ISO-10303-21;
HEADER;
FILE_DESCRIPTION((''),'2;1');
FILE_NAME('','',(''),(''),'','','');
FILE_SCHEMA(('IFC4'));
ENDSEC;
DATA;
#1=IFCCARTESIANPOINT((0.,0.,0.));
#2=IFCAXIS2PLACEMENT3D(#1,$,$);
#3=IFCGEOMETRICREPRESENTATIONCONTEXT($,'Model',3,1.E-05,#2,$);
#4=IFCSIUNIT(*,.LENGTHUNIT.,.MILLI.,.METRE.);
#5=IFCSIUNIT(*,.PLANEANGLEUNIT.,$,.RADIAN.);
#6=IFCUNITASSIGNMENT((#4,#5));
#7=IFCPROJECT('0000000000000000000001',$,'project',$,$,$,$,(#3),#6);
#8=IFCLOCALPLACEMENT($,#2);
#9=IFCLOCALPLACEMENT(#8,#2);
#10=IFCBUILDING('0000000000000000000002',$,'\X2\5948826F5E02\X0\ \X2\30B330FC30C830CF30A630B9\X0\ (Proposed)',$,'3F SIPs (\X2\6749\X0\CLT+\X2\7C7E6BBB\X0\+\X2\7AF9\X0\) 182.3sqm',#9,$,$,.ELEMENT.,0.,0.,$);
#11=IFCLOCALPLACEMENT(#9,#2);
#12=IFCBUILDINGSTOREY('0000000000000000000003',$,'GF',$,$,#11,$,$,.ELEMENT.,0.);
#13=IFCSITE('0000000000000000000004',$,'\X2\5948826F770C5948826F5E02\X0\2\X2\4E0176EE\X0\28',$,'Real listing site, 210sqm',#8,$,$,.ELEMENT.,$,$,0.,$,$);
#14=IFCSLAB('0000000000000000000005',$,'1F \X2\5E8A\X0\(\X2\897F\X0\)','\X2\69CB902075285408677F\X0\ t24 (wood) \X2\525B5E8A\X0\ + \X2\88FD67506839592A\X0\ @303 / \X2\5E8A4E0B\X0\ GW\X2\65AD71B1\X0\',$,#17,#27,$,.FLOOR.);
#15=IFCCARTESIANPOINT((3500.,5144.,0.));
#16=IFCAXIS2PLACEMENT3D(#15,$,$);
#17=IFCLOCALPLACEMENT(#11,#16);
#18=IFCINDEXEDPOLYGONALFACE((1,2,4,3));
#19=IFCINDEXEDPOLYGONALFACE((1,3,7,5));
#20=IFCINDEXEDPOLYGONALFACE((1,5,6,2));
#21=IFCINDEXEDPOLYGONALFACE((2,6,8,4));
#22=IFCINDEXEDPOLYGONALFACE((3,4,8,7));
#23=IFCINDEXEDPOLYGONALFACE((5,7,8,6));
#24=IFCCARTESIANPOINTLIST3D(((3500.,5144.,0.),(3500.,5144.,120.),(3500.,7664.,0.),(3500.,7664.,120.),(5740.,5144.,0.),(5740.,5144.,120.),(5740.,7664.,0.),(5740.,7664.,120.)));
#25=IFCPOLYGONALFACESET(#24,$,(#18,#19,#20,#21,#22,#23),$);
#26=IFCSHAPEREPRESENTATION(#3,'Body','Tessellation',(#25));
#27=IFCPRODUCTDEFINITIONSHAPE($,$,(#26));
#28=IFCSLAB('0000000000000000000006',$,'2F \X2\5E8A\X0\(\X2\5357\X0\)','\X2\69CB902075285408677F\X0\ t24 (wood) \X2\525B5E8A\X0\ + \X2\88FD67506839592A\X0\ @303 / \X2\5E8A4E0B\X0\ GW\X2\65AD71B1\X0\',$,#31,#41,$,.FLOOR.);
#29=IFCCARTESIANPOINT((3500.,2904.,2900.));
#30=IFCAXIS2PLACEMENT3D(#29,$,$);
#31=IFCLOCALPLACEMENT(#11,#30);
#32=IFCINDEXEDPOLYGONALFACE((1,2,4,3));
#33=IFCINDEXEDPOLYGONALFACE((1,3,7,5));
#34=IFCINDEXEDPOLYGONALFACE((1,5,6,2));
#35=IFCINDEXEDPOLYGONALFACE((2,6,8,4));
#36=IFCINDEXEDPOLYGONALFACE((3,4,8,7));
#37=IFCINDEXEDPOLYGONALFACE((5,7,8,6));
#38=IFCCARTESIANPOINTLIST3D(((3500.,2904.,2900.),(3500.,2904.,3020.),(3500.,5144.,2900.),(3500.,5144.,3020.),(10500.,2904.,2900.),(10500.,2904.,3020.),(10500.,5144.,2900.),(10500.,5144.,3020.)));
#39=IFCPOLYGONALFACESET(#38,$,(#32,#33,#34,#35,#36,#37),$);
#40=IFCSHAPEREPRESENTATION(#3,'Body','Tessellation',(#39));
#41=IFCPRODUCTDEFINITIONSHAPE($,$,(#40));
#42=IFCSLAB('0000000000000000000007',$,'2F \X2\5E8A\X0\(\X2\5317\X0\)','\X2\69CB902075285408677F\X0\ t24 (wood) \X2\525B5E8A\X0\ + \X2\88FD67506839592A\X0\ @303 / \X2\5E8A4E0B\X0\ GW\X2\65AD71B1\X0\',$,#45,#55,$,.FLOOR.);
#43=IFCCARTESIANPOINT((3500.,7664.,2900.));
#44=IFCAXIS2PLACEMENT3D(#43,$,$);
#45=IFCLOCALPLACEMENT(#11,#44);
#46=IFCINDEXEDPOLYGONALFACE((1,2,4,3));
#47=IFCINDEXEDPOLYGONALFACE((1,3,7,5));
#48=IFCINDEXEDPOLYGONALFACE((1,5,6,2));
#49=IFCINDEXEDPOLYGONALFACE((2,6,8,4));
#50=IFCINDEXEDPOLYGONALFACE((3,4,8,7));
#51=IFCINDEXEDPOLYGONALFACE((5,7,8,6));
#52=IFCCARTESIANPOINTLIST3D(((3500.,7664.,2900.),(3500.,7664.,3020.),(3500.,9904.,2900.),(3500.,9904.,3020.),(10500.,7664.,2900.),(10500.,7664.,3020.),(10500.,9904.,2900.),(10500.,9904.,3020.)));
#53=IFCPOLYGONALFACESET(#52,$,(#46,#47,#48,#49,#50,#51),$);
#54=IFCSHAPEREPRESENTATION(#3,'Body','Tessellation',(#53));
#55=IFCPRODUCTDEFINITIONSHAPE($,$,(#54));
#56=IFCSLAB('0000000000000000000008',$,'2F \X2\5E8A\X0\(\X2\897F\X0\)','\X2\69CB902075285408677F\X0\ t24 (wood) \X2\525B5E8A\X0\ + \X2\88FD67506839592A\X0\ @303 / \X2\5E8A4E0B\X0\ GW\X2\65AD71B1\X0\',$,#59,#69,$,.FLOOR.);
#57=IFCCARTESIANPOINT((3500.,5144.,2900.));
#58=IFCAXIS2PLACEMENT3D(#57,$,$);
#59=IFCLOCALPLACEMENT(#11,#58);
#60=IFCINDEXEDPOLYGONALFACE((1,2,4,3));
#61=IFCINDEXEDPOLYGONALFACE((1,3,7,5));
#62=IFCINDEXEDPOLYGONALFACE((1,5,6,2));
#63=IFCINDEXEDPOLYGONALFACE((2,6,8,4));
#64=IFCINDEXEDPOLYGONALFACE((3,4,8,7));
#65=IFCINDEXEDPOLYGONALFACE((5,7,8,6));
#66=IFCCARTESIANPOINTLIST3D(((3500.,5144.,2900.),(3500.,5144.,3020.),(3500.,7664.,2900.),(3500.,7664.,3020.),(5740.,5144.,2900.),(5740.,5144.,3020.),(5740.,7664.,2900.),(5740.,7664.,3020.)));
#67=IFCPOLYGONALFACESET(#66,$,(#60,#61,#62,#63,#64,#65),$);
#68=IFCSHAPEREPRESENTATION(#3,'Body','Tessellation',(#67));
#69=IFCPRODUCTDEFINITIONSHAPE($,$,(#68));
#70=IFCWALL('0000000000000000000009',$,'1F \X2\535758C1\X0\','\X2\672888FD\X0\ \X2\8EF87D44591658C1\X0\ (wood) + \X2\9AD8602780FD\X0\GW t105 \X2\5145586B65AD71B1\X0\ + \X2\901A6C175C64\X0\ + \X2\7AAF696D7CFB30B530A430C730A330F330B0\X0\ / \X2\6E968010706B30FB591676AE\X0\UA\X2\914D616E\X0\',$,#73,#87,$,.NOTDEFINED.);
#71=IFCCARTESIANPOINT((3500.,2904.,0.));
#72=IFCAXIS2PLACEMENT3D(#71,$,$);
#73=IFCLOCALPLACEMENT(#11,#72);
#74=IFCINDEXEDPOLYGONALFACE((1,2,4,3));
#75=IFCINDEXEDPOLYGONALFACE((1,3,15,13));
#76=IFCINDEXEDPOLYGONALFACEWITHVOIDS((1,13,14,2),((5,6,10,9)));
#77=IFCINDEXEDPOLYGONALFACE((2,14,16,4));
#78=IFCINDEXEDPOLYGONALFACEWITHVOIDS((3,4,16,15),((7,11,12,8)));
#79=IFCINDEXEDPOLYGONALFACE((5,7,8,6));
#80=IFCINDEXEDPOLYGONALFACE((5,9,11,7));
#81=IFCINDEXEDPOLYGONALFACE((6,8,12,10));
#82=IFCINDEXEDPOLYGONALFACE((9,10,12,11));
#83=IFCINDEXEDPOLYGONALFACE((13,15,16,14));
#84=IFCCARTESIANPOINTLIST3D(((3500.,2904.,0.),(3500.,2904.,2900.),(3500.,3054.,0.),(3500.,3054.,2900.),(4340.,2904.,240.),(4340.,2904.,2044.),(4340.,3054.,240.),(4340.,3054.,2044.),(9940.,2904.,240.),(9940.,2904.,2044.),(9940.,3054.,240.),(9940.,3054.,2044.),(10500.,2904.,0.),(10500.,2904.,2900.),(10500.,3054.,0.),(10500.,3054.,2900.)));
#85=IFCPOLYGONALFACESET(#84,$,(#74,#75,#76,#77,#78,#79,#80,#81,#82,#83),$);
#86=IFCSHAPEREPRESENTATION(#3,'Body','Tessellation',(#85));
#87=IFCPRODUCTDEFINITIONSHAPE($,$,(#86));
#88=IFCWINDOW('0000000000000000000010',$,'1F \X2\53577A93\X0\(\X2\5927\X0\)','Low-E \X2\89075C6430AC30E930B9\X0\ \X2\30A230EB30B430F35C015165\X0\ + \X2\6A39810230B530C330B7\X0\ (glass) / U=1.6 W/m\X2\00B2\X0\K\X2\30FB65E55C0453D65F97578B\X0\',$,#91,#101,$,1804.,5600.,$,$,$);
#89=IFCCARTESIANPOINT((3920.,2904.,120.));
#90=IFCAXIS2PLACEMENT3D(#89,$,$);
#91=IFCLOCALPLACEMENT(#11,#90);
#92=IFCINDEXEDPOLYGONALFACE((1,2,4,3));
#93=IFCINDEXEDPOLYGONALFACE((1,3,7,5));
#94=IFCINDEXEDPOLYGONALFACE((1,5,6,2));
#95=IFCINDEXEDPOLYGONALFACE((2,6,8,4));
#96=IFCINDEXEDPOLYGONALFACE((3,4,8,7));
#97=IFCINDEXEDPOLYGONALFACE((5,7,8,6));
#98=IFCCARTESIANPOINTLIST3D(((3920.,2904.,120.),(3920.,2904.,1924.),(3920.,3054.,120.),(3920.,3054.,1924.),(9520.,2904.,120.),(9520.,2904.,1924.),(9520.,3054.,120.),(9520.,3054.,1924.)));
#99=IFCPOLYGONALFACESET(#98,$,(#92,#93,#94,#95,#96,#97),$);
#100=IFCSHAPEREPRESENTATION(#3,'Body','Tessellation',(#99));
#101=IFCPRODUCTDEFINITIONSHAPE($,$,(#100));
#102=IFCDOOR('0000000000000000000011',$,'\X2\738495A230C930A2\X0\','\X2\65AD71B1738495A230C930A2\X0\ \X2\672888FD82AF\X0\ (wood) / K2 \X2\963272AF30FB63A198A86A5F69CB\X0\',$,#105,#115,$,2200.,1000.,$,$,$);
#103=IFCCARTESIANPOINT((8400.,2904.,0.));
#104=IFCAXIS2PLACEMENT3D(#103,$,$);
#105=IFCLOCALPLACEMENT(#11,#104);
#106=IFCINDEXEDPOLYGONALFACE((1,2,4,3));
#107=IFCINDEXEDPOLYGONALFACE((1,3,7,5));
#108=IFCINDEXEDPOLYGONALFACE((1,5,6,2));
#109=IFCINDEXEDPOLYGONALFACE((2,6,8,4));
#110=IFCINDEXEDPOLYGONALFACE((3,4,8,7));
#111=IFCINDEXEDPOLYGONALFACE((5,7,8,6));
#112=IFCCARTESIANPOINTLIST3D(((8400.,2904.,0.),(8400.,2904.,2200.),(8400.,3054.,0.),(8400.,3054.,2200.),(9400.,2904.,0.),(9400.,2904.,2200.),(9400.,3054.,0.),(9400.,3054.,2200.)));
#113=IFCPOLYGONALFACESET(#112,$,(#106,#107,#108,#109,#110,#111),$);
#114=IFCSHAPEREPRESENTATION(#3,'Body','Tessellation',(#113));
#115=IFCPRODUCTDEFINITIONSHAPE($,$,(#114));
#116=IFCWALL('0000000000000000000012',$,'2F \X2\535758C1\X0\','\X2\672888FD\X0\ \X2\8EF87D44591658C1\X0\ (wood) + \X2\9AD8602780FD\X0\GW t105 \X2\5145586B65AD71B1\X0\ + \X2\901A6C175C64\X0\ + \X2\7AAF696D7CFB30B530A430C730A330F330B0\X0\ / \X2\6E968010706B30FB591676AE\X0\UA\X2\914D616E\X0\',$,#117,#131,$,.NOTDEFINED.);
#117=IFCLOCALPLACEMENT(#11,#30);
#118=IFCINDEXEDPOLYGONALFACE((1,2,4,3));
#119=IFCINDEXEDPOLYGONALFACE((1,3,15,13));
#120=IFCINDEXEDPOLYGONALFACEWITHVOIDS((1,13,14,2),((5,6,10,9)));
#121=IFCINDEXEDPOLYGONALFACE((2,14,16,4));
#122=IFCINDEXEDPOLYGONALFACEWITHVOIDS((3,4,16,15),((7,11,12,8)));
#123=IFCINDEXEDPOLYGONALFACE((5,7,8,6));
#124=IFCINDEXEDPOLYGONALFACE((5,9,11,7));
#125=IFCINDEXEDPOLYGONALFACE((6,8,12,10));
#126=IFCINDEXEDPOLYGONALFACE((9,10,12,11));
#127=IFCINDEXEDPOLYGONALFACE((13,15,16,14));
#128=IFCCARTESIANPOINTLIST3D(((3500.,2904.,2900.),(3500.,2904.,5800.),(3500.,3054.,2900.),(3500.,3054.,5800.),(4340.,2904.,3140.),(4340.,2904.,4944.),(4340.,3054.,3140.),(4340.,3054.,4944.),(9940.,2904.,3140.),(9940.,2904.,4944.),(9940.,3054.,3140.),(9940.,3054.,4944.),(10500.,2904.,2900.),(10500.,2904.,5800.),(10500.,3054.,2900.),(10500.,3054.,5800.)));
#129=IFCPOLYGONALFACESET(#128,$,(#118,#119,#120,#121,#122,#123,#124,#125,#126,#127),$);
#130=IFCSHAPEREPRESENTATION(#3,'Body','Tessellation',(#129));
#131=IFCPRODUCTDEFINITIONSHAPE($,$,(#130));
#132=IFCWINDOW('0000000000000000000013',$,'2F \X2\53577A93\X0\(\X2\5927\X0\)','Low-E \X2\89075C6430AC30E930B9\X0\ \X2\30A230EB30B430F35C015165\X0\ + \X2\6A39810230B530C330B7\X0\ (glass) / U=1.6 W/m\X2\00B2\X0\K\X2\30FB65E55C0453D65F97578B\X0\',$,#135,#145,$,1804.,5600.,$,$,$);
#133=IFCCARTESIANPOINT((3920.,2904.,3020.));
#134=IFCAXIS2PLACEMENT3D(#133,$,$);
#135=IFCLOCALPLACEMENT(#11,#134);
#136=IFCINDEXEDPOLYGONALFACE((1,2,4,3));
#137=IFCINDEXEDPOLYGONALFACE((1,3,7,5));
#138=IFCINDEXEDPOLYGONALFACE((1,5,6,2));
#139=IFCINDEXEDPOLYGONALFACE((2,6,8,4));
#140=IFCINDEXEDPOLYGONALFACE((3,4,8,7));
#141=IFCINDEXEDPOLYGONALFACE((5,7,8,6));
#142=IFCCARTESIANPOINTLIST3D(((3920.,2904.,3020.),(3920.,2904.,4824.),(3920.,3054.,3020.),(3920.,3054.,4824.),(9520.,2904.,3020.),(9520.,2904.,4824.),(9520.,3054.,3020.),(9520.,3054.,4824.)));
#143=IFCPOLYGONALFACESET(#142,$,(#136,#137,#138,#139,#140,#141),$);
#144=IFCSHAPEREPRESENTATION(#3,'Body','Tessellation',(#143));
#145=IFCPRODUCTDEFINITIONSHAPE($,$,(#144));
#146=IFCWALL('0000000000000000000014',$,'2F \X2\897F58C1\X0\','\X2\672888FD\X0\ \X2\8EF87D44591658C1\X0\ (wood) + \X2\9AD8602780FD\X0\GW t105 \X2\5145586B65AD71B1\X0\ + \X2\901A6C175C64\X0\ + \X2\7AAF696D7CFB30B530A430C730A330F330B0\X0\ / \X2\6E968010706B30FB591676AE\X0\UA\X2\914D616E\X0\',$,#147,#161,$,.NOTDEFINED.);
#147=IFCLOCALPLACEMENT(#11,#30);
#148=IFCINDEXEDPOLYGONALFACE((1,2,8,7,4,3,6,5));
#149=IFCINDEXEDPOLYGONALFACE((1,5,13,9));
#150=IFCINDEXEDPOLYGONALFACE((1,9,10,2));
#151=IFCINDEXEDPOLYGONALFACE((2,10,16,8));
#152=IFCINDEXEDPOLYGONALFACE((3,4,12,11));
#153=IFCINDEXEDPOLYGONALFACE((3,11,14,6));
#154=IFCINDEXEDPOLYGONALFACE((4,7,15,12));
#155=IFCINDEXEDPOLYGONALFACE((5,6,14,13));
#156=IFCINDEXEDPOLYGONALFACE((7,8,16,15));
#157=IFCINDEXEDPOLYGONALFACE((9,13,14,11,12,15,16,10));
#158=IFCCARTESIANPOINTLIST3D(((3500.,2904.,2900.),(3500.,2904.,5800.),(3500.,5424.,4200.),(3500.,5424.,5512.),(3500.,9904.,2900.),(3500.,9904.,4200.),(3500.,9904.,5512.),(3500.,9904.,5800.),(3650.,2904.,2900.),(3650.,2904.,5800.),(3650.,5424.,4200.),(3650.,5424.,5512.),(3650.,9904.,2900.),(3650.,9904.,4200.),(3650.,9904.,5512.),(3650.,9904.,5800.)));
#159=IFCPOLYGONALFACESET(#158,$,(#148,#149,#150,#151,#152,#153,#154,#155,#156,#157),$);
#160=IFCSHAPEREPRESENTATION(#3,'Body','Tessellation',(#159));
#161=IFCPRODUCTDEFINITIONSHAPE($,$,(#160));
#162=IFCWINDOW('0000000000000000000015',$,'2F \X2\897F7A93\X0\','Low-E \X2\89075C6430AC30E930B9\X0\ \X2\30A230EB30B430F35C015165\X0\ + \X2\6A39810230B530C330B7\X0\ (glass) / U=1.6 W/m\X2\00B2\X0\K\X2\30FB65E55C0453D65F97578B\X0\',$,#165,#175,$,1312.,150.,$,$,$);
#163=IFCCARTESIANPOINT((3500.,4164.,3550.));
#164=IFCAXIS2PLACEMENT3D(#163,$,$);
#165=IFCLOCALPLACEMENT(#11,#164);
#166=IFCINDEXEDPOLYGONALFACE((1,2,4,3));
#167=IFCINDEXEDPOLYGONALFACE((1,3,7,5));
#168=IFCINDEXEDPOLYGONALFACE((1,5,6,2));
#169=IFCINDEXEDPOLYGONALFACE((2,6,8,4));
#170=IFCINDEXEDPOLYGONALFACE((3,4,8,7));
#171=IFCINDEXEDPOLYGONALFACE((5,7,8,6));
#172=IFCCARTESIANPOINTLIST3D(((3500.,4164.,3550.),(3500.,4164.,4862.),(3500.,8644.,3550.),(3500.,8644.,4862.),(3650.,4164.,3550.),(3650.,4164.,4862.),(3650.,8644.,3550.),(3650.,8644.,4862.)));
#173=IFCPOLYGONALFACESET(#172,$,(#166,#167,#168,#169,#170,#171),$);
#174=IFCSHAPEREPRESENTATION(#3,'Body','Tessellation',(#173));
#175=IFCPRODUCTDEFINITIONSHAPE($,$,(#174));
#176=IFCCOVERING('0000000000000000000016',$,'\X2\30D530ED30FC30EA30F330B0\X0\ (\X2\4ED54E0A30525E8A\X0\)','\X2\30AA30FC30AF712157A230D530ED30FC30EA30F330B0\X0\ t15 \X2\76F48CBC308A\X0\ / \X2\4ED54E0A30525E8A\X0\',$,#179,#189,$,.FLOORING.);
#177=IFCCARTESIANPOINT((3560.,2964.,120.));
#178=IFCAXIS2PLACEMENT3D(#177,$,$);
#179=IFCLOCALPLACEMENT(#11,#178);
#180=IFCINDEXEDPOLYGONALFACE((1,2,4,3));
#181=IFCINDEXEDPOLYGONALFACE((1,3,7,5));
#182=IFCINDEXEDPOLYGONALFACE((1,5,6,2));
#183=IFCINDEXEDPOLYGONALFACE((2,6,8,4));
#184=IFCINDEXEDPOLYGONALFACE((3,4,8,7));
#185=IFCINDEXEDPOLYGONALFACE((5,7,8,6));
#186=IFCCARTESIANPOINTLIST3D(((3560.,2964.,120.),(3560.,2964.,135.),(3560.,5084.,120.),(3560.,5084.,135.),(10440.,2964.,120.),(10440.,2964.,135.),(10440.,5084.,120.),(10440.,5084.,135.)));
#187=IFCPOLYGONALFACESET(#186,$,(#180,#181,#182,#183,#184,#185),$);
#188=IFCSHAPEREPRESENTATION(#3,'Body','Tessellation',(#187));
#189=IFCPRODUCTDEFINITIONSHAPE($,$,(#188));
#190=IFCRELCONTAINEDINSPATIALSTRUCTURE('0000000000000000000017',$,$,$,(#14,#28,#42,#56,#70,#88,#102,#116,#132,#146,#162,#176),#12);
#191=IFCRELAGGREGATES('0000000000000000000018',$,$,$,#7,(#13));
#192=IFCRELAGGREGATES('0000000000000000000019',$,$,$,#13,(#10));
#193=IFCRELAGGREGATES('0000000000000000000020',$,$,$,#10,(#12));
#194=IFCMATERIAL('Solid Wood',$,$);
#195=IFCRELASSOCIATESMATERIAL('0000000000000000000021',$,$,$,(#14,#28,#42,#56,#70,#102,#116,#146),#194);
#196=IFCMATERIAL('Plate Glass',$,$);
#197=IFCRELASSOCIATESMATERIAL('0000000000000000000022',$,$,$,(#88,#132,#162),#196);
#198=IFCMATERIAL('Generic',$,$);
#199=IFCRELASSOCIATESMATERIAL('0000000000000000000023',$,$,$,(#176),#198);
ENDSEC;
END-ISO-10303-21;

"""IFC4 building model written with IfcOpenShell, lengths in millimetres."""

from ifc_helpers import new_model, si_unit, frame, frame_2d, origin, place, context, project, spatial, rectangle, extrude, material, element, fill, save


model = new_model("IFC4")

# Units and contexts
model_context = context("Model", 3, precision=1e-05, world=origin())
ifc_project = project(units=[si_unit("LENGTHUNIT", "METRE", prefix="MILLI"), si_unit("PLANEANGLEUNIT", "RADIAN")], contexts=[model_context])

# Site, building, storey
site_placement = place(None, origin())
site = spatial("IfcSite", under=ifc_project, at=site_placement, Name="奈良県奈良市2丁目28", ObjectType="Real listing site, 210sqm", CompositionType="ELEMENT", RefElevation=0.0)
building_placement = place(site_placement, origin())
building = spatial("IfcBuilding", under=site, at=building_placement, Name="奈良市 コートハウス (Proposed)", ObjectType="3F SIPs (杉CLT+籾殻+竹) 182.3sqm", CompositionType="ELEMENT", ElevationOfRefHeight=0.0, ElevationOfTerrain=0.0)
storey_placement = place(building_placement, origin())
storey = spatial("IfcBuildingStorey", under=building, at=storey_placement, Name="GF", CompositionType="ELEMENT", Elevation=0.0)

# Slabs
ifc_material_1 = material(Name="Solid Wood")
slab_1_placement = place(storey_placement, frame((3500.0, 5144.0, 0.0)))
element("IfcSlab", 1, at=slab_1_placement, inside=storey, material=ifc_material_1, Name="1F 床(西)", Description="構造用合板 t24 (wood) 剛床 + 製材根太 @303 / 床下 GW断熱", PredefinedType="FLOOR", context=model_context, shape_type="SweptSolid", body=[
    extrude(rectangle(XDim=2240.0, YDim=2520.0, at=frame_2d((1120.0, 1260.0))), frame((3500.0, 5144.0, 0.0)), (0.0, 0.0, 1.0), 120.0),
])
slab_2_placement = place(storey_placement, frame((3500.0, 2904.0, 2900.0)))
element("IfcSlab", 2, at=slab_2_placement, inside=storey, material=ifc_material_1, Name="2F 床(南)", Description="構造用合板 t24 (wood) 剛床 + 製材根太 @303 / 床下 GW断熱", PredefinedType="FLOOR", context=model_context, shape_type="SweptSolid", body=[
    extrude(rectangle(XDim=7000.0, YDim=2240.0, at=frame_2d((3500.0, 1120.0))), frame((3500.0, 2904.0, 2900.0)), (0.0, 0.0, 1.0), 120.0),
])
slab_3_placement = place(storey_placement, frame((3500.0, 7664.0, 2900.0)))
element("IfcSlab", 3, at=slab_3_placement, inside=storey, material=ifc_material_1, Name="2F 床(北)", Description="構造用合板 t24 (wood) 剛床 + 製材根太 @303 / 床下 GW断熱", PredefinedType="FLOOR", context=model_context, shape_type="SweptSolid", body=[
    extrude(rectangle(XDim=7000.0, YDim=2240.0, at=frame_2d((3500.0, 1120.0))), frame((3500.0, 7664.0, 2900.0)), (0.0, 0.0, 1.0), 120.0),
])
slab_4_placement = place(storey_placement, frame((3500.0, 5144.0, 2900.0)))
element("IfcSlab", 4, at=slab_4_placement, inside=storey, material=ifc_material_1, Name="2F 床(西)", Description="構造用合板 t24 (wood) 剛床 + 製材根太 @303 / 床下 GW断熱", PredefinedType="FLOOR", context=model_context, shape_type="SweptSolid", body=[
    extrude(rectangle(XDim=2240.0, YDim=2520.0, at=frame_2d((1120.0, 1260.0))), frame((3500.0, 5144.0, 2900.0)), (0.0, 0.0, 1.0), 120.0),
])

# Wall, openings, window, door
wall_1_placement = place(storey_placement, frame((3500.0, 2904.0, 0.0)))
wall_1 = element("IfcWall", 5, at=wall_1_placement, inside=storey, material=ifc_material_1, Name="1F 南壁", Description="木製 軸組外壁 (wood) + 高性能GW t105 充填断熱 + 通気層 + 窯業系サイディング / 準耐火・外皮UA配慮", PredefinedType="NOTDEFINED", context=model_context, shape_type="SweptSolid", body=[
    extrude(rectangle(XDim=7000.0, YDim=150.0, at=frame_2d((3500.0, 75.0))), frame((3500.0, 2904.0, 0.0)), (0.0, 0.0, 1.0), 2900.0),
])
opening_1_placement = place(storey_placement, frame((3920.0, 2904.0, 120.0)))
opening_1 = element("IfcOpeningElement", 6, at=opening_1_placement, cuts=wall_1, PredefinedType="NOTDEFINED", context=model_context, shape_type="SweptSolid", body=[
    extrude(rectangle(XDim=5600.0, YDim=150.0, at=frame_2d((2800.0, 75.0))), frame((3920.0, 2904.0, 120.0)), (0.0, 0.0, 1.0), 1804.0),
])
opening_2_placement = place(storey_placement, frame((8400.0, 2904.0, 0.0)))
opening_2 = element("IfcOpeningElement", 7, at=opening_2_placement, cuts=wall_1, PredefinedType="NOTDEFINED", context=model_context, shape_type="SweptSolid", body=[
    extrude(rectangle(XDim=1000.0, YDim=150.0, at=frame_2d((500.0, 75.0))), frame((8400.0, 2904.0, 0.0)), (0.0, 0.0, 1.0), 2200.0),
])
ifc_material_2 = material(Name="Plate Glass")
window_1_placement = place(storey_placement, frame((3920.0, 2904.0, 120.0)))
window_1 = element("IfcWindow", 8, at=window_1_placement, inside=storey, material=ifc_material_2, Name="1F 南窓(大)", Description="Low-E 複層ガラス アルゴン封入 + 樹脂サッシ (glass) / U=1.6 W/m²K・日射取得型", OverallHeight=1804.0, OverallWidth=5600.0, context=model_context, shape_type="SweptSolid", body=[
    extrude(rectangle(XDim=5600.0, YDim=150.0, at=frame_2d((2800.0, 75.0))), frame((3920.0, 2904.0, 120.0)), (0.0, 0.0, 1.0), 1804.0),
])
fill(opening_1, window_1)
door_placement = place(storey_placement, frame((8400.0, 2904.0, 0.0)))
door = element("IfcDoor", 9, at=door_placement, inside=storey, material=ifc_material_1, Name="玄関ドア", Description="断熱玄関ドア 木製芯 (wood) / K2 防犯・採風機構", OverallHeight=2200.0, OverallWidth=1000.0, context=model_context, shape_type="SweptSolid", body=[
    extrude(rectangle(XDim=1000.0, YDim=150.0, at=frame_2d((500.0, 75.0))), frame((8400.0, 2904.0, 0.0)), (0.0, 0.0, 1.0), 2200.0),
])
fill(opening_2, door)

# Wall, opening, window
wall_2_placement = place(storey_placement, frame((3500.0, 2904.0, 2900.0)))
wall_2 = element("IfcWall", 10, at=wall_2_placement, inside=storey, material=ifc_material_1, Name="2F 南壁", Description="木製 軸組外壁 (wood) + 高性能GW t105 充填断熱 + 通気層 + 窯業系サイディング / 準耐火・外皮UA配慮", PredefinedType="NOTDEFINED", context=model_context, shape_type="SweptSolid", body=[
    extrude(rectangle(XDim=7000.0, YDim=150.0, at=frame_2d((3500.0, 75.0))), frame((3500.0, 2904.0, 2900.0)), (0.0, 0.0, 1.0), 2900.0),
])
opening_3_placement = place(storey_placement, frame((3920.0, 2904.0, 3020.0)))
opening_3 = element("IfcOpeningElement", 11, at=opening_3_placement, cuts=wall_2, PredefinedType="NOTDEFINED", context=model_context, shape_type="SweptSolid", body=[
    extrude(rectangle(XDim=5600.0, YDim=150.0, at=frame_2d((2800.0, 75.0))), frame((3920.0, 2904.0, 3020.0)), (0.0, 0.0, 1.0), 1804.0),
])
window_2_placement = place(storey_placement, frame((3920.0, 2904.0, 3020.0)))
window_2 = element("IfcWindow", 12, at=window_2_placement, inside=storey, material=ifc_material_2, Name="2F 南窓(大)", Description="Low-E 複層ガラス アルゴン封入 + 樹脂サッシ (glass) / U=1.6 W/m²K・日射取得型", OverallHeight=1804.0, OverallWidth=5600.0, context=model_context, shape_type="SweptSolid", body=[
    extrude(rectangle(XDim=5600.0, YDim=150.0, at=frame_2d((2800.0, 75.0))), frame((3920.0, 2904.0, 3020.0)), (0.0, 0.0, 1.0), 1804.0),
])
fill(opening_3, window_2)

# Wall, opening, window
wall_3_placement = place(storey_placement, frame((3500.0, 2904.0, 2900.0)))
wall_3 = element("IfcWall", 13, at=wall_3_placement, inside=storey, material=ifc_material_1, Name="2F 西壁", Description="木製 軸組外壁 (wood) + 高性能GW t105 充填断熱 + 通気層 + 窯業系サイディング / 準耐火・外皮UA配慮", PredefinedType="NOTDEFINED", context=model_context, shape_type="SweptSolid", body=[
    extrude(rectangle(XDim=150.0, YDim=7000.0, at=frame_2d((75.0, 3500.0))), frame((3500.0, 2904.0, 2900.0)), (0.0, 0.0, 1.0), 2900.0),
])
opening_4_placement = place(storey_placement, frame((3500.0, 4164.0, 3550.0)))
opening_4 = element("IfcOpeningElement", 14, at=opening_4_placement, cuts=wall_3, PredefinedType="NOTDEFINED", context=model_context, shape_type="SweptSolid", body=[
    extrude(rectangle(XDim=150.0, YDim=4480.0, at=frame_2d((75.0, 2240.0))), frame((3500.0, 4164.0, 3550.0)), (0.0, 0.0, 1.0), 1312.0),
])
window_3_placement = place(storey_placement, frame((3500.0, 4164.0, 3550.0)))
window_3 = element("IfcWindow", 15, at=window_3_placement, inside=storey, material=ifc_material_2, Name="2F 西窓", Description="Low-E 複層ガラス アルゴン封入 + 樹脂サッシ (glass) / U=1.6 W/m²K・日射取得型", OverallHeight=1312.0, OverallWidth=150.0, context=model_context, shape_type="SweptSolid", body=[
    extrude(rectangle(XDim=150.0, YDim=4480.0, at=frame_2d((75.0, 2240.0))), frame((3500.0, 4164.0, 3550.0)), (0.0, 0.0, 1.0), 1312.0),
])
fill(opening_4, window_3)

# Covering
ifc_material_3 = material(Name="Generic")
covering_1_placement = place(storey_placement, frame((3560.0, 2964.0, 120.0)))
element("IfcCovering", 16, at=covering_1_placement, inside=storey, material=ifc_material_3, Name="フローリング (仕上げ床)", Description="オーク無垢フローリング t15 直貼り / 仕上げ床", PredefinedType="FLOORING", context=model_context, shape_type="SweptSolid", body=[
    extrude(rectangle(XDim=6880.0, YDim=2120.0, at=frame_2d((3440.0, 1060.0))), frame((3560.0, 2964.0, 120.0)), (0.0, 0.0, 1.0), 15.0),
])

save(model, "model.ifc")
